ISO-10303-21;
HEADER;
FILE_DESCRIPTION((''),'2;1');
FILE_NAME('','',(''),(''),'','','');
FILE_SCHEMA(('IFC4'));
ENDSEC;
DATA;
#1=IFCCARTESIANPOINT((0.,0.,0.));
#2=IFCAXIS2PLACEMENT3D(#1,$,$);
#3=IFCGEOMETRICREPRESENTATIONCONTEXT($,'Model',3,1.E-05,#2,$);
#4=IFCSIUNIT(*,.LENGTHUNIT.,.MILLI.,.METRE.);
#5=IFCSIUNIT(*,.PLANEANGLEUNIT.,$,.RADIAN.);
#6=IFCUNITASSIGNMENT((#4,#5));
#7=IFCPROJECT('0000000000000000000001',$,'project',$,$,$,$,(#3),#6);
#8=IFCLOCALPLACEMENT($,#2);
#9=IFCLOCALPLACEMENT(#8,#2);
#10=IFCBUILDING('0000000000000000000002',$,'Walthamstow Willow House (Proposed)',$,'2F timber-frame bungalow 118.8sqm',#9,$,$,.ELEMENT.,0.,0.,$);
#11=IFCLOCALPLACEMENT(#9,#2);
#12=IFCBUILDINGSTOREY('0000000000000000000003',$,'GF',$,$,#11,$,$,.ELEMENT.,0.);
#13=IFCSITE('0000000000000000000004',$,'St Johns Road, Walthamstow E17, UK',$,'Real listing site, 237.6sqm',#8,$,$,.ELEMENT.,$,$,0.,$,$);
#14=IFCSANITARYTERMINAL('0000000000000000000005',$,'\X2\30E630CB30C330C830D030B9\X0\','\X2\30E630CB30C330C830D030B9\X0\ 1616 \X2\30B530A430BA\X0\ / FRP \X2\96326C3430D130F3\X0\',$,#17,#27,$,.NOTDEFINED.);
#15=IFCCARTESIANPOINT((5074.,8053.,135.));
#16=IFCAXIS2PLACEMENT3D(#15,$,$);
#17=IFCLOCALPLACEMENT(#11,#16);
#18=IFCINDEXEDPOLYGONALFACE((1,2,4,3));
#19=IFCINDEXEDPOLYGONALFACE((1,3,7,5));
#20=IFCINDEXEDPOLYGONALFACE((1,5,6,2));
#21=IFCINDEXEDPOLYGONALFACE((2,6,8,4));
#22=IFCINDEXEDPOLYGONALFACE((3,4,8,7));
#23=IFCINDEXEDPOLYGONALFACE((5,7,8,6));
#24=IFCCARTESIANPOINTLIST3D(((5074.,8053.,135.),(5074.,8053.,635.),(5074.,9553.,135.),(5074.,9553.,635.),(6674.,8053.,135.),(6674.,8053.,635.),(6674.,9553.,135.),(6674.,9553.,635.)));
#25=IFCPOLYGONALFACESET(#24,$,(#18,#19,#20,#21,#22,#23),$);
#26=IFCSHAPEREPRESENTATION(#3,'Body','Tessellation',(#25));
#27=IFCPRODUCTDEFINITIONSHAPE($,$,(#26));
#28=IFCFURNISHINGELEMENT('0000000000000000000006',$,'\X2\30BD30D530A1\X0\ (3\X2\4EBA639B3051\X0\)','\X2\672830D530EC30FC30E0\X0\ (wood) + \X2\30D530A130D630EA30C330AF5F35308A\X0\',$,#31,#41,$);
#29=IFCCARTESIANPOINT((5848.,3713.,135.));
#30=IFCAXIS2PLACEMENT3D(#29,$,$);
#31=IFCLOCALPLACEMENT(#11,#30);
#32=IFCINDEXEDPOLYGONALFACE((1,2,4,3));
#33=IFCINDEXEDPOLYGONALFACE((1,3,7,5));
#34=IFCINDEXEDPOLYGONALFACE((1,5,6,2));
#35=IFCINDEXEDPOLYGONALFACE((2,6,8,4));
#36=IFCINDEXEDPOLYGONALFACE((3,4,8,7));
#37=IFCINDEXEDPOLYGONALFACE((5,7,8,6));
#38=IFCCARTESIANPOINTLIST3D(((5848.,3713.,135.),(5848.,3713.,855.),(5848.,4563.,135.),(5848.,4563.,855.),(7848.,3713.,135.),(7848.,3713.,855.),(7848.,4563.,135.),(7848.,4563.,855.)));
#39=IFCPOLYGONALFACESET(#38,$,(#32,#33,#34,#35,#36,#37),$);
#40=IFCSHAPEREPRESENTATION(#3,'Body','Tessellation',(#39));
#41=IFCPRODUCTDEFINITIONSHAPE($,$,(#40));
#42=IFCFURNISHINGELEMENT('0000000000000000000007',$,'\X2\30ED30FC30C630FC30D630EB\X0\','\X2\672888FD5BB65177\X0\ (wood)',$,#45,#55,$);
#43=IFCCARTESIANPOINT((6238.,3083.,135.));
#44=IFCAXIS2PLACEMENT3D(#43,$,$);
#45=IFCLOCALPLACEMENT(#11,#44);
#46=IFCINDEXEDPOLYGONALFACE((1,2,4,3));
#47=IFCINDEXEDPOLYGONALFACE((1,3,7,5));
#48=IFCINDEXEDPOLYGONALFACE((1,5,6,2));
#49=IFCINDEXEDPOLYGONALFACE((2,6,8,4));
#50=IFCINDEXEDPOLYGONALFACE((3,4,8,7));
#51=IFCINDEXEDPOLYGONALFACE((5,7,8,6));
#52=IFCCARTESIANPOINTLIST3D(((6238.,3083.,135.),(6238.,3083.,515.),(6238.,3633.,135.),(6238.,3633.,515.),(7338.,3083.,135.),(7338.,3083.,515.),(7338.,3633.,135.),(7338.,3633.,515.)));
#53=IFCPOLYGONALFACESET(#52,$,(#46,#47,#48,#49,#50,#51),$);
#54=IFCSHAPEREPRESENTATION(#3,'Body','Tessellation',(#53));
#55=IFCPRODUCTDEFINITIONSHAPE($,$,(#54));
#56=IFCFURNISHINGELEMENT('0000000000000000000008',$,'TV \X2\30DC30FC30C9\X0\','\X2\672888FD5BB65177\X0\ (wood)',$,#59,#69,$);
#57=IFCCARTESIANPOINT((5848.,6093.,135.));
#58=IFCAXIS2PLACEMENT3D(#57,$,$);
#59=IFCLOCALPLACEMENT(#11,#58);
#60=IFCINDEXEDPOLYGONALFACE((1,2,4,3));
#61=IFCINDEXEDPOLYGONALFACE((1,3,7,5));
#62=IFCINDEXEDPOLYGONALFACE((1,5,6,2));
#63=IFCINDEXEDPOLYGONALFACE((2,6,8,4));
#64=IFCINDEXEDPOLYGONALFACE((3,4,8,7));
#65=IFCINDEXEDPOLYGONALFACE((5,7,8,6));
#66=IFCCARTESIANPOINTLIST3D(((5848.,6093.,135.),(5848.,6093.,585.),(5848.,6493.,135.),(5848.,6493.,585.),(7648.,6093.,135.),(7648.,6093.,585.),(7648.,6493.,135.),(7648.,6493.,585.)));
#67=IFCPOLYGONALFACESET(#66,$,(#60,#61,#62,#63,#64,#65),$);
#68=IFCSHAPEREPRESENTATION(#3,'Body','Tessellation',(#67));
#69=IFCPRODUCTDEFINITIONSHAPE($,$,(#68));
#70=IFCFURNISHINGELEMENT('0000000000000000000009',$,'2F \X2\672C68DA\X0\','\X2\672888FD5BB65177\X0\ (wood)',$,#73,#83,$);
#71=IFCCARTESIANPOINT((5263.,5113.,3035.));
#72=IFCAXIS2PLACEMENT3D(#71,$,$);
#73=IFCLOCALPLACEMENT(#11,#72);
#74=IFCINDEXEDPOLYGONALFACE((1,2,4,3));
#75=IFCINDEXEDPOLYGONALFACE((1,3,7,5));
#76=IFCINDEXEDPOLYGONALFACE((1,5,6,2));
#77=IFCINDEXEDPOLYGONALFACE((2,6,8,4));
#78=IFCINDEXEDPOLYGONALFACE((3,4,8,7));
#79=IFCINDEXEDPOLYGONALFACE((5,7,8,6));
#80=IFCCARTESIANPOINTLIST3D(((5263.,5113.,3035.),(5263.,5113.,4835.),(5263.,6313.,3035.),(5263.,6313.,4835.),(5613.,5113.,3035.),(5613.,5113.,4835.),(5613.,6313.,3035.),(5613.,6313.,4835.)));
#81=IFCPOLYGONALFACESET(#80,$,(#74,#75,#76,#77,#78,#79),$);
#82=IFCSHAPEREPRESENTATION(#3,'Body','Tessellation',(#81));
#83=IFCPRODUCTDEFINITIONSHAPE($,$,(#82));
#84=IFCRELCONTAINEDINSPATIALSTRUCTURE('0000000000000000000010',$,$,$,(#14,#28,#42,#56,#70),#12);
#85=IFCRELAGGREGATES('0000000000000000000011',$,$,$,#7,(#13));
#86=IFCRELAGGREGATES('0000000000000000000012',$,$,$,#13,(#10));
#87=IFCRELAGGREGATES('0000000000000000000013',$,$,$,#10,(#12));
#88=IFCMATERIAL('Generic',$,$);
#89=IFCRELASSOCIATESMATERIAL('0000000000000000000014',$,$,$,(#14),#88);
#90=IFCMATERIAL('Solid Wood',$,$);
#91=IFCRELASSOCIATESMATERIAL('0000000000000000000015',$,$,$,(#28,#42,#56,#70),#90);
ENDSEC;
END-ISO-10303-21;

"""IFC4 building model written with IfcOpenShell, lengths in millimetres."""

from ifc_helpers import new_model, si_unit, frame, frame_2d, origin, place, context, project, spatial, rectangle, extrude, material, element, save


model = new_model("IFC4")

# Units and contexts
model_context = context("Model", 3, precision=1e-05, world=origin())
ifc_project = project(units=[si_unit("LENGTHUNIT", "METRE", prefix="MILLI"), si_unit("PLANEANGLEUNIT", "RADIAN")], contexts=[model_context])

# Site, building, storey
site_placement = place(None, origin())
site = spatial("IfcSite", under=ifc_project, at=site_placement, Name="St Johns Road, Walthamstow E17, UK", ObjectType="Real listing site, 237.6sqm", CompositionType="ELEMENT", RefElevation=0.0)
building_placement = place(site_placement, origin())
building = spatial("IfcBuilding", under=site, at=building_placement, Name="Walthamstow Willow House (Proposed)", ObjectType="2F timber-frame bungalow 118.8sqm", CompositionType="ELEMENT", ElevationOfRefHeight=0.0, ElevationOfTerrain=0.0)
storey_placement = place(building_placement, origin())
storey = spatial("IfcBuildingStorey", under=building, at=storey_placement, Name="GF", CompositionType="ELEMENT", Elevation=0.0)

# Shared definitions
ifc_material_1 = material(Name="Solid Wood")

# Sanitary terminal
ifc_material_2 = material(Name="Generic")
sanitary_terminal_placement = place(storey_placement, frame((5074.0, 8053.0, 135.0)))
element("IfcSanitaryTerminal", 1, at=sanitary_terminal_placement, inside=storey, material=ifc_material_2, Name="ユニットバス", Description="ユニットバス 1616 サイズ / FRP 防水パン", PredefinedType="NOTDEFINED", context=model_context, shape_type="SweptSolid", body=[
    extrude(rectangle(XDim=1600.0, YDim=1500.0, at=frame_2d((800.0, 750.0))), frame((5074.0, 8053.0, 135.0)), (0.0, 0.0, 1.0), 500.0),
])

# Furnishing elements
furnishing_1_placement = place(storey_placement, frame((5848.0, 3713.0, 135.0)))
element("IfcFurnishingElement", 2, at=furnishing_1_placement, inside=storey, material=ifc_material_1, Name="ソファ (3人掛け)", Description="木フレーム (wood) + ファブリック張り", context=model_context, shape_type="SweptSolid", body=[
    extrude(rectangle(XDim=2000.0, YDim=850.0, at=frame_2d((1000.0, 425.0))), frame((5848.0, 3713.0, 135.0)), (0.0, 0.0, 1.0), 720.0),
])
furnishing_2_placement = place(storey_placement, frame((6238.0, 3083.0, 135.0)))
element("IfcFurnishingElement", 3, at=furnishing_2_placement, inside=storey, material=ifc_material_1, Name="ローテーブル", Description="木製家具 (wood)", context=model_context, shape_type="SweptSolid", body=[
    extrude(rectangle(XDim=1100.0, YDim=550.0, at=frame_2d((550.0, 275.0))), frame((6238.0, 3083.0, 135.0)), (0.0, 0.0, 1.0), 380.0),
])
furnishing_3_placement = place(storey_placement, frame((5848.0, 6093.0, 135.0)))
element("IfcFurnishingElement", 4, at=furnishing_3_placement, inside=storey, material=ifc_material_1, Name="TV ボード", Description="木製家具 (wood)", context=model_context, shape_type="SweptSolid", body=[
    extrude(rectangle(XDim=1800.0, YDim=400.0, at=frame_2d((900.0, 200.0))), frame((5848.0, 6093.0, 135.0)), (0.0, 0.0, 1.0), 450.0),
])
furnishing_4_placement = place(storey_placement, frame((5263.0, 5113.0, 3035.0)))
element("IfcFurnishingElement", 5, at=furnishing_4_placement, inside=storey, material=ifc_material_1, Name="2F 本棚", Description="木製家具 (wood)", context=model_context, shape_type="SweptSolid", body=[
    extrude(rectangle(XDim=350.0, YDim=1200.0, at=frame_2d((175.0, 600.0))), frame((5263.0, 5113.0, 3035.0)), (0.0, 0.0, 1.0), 1800.0),
])

save(model, "model.ifc")
